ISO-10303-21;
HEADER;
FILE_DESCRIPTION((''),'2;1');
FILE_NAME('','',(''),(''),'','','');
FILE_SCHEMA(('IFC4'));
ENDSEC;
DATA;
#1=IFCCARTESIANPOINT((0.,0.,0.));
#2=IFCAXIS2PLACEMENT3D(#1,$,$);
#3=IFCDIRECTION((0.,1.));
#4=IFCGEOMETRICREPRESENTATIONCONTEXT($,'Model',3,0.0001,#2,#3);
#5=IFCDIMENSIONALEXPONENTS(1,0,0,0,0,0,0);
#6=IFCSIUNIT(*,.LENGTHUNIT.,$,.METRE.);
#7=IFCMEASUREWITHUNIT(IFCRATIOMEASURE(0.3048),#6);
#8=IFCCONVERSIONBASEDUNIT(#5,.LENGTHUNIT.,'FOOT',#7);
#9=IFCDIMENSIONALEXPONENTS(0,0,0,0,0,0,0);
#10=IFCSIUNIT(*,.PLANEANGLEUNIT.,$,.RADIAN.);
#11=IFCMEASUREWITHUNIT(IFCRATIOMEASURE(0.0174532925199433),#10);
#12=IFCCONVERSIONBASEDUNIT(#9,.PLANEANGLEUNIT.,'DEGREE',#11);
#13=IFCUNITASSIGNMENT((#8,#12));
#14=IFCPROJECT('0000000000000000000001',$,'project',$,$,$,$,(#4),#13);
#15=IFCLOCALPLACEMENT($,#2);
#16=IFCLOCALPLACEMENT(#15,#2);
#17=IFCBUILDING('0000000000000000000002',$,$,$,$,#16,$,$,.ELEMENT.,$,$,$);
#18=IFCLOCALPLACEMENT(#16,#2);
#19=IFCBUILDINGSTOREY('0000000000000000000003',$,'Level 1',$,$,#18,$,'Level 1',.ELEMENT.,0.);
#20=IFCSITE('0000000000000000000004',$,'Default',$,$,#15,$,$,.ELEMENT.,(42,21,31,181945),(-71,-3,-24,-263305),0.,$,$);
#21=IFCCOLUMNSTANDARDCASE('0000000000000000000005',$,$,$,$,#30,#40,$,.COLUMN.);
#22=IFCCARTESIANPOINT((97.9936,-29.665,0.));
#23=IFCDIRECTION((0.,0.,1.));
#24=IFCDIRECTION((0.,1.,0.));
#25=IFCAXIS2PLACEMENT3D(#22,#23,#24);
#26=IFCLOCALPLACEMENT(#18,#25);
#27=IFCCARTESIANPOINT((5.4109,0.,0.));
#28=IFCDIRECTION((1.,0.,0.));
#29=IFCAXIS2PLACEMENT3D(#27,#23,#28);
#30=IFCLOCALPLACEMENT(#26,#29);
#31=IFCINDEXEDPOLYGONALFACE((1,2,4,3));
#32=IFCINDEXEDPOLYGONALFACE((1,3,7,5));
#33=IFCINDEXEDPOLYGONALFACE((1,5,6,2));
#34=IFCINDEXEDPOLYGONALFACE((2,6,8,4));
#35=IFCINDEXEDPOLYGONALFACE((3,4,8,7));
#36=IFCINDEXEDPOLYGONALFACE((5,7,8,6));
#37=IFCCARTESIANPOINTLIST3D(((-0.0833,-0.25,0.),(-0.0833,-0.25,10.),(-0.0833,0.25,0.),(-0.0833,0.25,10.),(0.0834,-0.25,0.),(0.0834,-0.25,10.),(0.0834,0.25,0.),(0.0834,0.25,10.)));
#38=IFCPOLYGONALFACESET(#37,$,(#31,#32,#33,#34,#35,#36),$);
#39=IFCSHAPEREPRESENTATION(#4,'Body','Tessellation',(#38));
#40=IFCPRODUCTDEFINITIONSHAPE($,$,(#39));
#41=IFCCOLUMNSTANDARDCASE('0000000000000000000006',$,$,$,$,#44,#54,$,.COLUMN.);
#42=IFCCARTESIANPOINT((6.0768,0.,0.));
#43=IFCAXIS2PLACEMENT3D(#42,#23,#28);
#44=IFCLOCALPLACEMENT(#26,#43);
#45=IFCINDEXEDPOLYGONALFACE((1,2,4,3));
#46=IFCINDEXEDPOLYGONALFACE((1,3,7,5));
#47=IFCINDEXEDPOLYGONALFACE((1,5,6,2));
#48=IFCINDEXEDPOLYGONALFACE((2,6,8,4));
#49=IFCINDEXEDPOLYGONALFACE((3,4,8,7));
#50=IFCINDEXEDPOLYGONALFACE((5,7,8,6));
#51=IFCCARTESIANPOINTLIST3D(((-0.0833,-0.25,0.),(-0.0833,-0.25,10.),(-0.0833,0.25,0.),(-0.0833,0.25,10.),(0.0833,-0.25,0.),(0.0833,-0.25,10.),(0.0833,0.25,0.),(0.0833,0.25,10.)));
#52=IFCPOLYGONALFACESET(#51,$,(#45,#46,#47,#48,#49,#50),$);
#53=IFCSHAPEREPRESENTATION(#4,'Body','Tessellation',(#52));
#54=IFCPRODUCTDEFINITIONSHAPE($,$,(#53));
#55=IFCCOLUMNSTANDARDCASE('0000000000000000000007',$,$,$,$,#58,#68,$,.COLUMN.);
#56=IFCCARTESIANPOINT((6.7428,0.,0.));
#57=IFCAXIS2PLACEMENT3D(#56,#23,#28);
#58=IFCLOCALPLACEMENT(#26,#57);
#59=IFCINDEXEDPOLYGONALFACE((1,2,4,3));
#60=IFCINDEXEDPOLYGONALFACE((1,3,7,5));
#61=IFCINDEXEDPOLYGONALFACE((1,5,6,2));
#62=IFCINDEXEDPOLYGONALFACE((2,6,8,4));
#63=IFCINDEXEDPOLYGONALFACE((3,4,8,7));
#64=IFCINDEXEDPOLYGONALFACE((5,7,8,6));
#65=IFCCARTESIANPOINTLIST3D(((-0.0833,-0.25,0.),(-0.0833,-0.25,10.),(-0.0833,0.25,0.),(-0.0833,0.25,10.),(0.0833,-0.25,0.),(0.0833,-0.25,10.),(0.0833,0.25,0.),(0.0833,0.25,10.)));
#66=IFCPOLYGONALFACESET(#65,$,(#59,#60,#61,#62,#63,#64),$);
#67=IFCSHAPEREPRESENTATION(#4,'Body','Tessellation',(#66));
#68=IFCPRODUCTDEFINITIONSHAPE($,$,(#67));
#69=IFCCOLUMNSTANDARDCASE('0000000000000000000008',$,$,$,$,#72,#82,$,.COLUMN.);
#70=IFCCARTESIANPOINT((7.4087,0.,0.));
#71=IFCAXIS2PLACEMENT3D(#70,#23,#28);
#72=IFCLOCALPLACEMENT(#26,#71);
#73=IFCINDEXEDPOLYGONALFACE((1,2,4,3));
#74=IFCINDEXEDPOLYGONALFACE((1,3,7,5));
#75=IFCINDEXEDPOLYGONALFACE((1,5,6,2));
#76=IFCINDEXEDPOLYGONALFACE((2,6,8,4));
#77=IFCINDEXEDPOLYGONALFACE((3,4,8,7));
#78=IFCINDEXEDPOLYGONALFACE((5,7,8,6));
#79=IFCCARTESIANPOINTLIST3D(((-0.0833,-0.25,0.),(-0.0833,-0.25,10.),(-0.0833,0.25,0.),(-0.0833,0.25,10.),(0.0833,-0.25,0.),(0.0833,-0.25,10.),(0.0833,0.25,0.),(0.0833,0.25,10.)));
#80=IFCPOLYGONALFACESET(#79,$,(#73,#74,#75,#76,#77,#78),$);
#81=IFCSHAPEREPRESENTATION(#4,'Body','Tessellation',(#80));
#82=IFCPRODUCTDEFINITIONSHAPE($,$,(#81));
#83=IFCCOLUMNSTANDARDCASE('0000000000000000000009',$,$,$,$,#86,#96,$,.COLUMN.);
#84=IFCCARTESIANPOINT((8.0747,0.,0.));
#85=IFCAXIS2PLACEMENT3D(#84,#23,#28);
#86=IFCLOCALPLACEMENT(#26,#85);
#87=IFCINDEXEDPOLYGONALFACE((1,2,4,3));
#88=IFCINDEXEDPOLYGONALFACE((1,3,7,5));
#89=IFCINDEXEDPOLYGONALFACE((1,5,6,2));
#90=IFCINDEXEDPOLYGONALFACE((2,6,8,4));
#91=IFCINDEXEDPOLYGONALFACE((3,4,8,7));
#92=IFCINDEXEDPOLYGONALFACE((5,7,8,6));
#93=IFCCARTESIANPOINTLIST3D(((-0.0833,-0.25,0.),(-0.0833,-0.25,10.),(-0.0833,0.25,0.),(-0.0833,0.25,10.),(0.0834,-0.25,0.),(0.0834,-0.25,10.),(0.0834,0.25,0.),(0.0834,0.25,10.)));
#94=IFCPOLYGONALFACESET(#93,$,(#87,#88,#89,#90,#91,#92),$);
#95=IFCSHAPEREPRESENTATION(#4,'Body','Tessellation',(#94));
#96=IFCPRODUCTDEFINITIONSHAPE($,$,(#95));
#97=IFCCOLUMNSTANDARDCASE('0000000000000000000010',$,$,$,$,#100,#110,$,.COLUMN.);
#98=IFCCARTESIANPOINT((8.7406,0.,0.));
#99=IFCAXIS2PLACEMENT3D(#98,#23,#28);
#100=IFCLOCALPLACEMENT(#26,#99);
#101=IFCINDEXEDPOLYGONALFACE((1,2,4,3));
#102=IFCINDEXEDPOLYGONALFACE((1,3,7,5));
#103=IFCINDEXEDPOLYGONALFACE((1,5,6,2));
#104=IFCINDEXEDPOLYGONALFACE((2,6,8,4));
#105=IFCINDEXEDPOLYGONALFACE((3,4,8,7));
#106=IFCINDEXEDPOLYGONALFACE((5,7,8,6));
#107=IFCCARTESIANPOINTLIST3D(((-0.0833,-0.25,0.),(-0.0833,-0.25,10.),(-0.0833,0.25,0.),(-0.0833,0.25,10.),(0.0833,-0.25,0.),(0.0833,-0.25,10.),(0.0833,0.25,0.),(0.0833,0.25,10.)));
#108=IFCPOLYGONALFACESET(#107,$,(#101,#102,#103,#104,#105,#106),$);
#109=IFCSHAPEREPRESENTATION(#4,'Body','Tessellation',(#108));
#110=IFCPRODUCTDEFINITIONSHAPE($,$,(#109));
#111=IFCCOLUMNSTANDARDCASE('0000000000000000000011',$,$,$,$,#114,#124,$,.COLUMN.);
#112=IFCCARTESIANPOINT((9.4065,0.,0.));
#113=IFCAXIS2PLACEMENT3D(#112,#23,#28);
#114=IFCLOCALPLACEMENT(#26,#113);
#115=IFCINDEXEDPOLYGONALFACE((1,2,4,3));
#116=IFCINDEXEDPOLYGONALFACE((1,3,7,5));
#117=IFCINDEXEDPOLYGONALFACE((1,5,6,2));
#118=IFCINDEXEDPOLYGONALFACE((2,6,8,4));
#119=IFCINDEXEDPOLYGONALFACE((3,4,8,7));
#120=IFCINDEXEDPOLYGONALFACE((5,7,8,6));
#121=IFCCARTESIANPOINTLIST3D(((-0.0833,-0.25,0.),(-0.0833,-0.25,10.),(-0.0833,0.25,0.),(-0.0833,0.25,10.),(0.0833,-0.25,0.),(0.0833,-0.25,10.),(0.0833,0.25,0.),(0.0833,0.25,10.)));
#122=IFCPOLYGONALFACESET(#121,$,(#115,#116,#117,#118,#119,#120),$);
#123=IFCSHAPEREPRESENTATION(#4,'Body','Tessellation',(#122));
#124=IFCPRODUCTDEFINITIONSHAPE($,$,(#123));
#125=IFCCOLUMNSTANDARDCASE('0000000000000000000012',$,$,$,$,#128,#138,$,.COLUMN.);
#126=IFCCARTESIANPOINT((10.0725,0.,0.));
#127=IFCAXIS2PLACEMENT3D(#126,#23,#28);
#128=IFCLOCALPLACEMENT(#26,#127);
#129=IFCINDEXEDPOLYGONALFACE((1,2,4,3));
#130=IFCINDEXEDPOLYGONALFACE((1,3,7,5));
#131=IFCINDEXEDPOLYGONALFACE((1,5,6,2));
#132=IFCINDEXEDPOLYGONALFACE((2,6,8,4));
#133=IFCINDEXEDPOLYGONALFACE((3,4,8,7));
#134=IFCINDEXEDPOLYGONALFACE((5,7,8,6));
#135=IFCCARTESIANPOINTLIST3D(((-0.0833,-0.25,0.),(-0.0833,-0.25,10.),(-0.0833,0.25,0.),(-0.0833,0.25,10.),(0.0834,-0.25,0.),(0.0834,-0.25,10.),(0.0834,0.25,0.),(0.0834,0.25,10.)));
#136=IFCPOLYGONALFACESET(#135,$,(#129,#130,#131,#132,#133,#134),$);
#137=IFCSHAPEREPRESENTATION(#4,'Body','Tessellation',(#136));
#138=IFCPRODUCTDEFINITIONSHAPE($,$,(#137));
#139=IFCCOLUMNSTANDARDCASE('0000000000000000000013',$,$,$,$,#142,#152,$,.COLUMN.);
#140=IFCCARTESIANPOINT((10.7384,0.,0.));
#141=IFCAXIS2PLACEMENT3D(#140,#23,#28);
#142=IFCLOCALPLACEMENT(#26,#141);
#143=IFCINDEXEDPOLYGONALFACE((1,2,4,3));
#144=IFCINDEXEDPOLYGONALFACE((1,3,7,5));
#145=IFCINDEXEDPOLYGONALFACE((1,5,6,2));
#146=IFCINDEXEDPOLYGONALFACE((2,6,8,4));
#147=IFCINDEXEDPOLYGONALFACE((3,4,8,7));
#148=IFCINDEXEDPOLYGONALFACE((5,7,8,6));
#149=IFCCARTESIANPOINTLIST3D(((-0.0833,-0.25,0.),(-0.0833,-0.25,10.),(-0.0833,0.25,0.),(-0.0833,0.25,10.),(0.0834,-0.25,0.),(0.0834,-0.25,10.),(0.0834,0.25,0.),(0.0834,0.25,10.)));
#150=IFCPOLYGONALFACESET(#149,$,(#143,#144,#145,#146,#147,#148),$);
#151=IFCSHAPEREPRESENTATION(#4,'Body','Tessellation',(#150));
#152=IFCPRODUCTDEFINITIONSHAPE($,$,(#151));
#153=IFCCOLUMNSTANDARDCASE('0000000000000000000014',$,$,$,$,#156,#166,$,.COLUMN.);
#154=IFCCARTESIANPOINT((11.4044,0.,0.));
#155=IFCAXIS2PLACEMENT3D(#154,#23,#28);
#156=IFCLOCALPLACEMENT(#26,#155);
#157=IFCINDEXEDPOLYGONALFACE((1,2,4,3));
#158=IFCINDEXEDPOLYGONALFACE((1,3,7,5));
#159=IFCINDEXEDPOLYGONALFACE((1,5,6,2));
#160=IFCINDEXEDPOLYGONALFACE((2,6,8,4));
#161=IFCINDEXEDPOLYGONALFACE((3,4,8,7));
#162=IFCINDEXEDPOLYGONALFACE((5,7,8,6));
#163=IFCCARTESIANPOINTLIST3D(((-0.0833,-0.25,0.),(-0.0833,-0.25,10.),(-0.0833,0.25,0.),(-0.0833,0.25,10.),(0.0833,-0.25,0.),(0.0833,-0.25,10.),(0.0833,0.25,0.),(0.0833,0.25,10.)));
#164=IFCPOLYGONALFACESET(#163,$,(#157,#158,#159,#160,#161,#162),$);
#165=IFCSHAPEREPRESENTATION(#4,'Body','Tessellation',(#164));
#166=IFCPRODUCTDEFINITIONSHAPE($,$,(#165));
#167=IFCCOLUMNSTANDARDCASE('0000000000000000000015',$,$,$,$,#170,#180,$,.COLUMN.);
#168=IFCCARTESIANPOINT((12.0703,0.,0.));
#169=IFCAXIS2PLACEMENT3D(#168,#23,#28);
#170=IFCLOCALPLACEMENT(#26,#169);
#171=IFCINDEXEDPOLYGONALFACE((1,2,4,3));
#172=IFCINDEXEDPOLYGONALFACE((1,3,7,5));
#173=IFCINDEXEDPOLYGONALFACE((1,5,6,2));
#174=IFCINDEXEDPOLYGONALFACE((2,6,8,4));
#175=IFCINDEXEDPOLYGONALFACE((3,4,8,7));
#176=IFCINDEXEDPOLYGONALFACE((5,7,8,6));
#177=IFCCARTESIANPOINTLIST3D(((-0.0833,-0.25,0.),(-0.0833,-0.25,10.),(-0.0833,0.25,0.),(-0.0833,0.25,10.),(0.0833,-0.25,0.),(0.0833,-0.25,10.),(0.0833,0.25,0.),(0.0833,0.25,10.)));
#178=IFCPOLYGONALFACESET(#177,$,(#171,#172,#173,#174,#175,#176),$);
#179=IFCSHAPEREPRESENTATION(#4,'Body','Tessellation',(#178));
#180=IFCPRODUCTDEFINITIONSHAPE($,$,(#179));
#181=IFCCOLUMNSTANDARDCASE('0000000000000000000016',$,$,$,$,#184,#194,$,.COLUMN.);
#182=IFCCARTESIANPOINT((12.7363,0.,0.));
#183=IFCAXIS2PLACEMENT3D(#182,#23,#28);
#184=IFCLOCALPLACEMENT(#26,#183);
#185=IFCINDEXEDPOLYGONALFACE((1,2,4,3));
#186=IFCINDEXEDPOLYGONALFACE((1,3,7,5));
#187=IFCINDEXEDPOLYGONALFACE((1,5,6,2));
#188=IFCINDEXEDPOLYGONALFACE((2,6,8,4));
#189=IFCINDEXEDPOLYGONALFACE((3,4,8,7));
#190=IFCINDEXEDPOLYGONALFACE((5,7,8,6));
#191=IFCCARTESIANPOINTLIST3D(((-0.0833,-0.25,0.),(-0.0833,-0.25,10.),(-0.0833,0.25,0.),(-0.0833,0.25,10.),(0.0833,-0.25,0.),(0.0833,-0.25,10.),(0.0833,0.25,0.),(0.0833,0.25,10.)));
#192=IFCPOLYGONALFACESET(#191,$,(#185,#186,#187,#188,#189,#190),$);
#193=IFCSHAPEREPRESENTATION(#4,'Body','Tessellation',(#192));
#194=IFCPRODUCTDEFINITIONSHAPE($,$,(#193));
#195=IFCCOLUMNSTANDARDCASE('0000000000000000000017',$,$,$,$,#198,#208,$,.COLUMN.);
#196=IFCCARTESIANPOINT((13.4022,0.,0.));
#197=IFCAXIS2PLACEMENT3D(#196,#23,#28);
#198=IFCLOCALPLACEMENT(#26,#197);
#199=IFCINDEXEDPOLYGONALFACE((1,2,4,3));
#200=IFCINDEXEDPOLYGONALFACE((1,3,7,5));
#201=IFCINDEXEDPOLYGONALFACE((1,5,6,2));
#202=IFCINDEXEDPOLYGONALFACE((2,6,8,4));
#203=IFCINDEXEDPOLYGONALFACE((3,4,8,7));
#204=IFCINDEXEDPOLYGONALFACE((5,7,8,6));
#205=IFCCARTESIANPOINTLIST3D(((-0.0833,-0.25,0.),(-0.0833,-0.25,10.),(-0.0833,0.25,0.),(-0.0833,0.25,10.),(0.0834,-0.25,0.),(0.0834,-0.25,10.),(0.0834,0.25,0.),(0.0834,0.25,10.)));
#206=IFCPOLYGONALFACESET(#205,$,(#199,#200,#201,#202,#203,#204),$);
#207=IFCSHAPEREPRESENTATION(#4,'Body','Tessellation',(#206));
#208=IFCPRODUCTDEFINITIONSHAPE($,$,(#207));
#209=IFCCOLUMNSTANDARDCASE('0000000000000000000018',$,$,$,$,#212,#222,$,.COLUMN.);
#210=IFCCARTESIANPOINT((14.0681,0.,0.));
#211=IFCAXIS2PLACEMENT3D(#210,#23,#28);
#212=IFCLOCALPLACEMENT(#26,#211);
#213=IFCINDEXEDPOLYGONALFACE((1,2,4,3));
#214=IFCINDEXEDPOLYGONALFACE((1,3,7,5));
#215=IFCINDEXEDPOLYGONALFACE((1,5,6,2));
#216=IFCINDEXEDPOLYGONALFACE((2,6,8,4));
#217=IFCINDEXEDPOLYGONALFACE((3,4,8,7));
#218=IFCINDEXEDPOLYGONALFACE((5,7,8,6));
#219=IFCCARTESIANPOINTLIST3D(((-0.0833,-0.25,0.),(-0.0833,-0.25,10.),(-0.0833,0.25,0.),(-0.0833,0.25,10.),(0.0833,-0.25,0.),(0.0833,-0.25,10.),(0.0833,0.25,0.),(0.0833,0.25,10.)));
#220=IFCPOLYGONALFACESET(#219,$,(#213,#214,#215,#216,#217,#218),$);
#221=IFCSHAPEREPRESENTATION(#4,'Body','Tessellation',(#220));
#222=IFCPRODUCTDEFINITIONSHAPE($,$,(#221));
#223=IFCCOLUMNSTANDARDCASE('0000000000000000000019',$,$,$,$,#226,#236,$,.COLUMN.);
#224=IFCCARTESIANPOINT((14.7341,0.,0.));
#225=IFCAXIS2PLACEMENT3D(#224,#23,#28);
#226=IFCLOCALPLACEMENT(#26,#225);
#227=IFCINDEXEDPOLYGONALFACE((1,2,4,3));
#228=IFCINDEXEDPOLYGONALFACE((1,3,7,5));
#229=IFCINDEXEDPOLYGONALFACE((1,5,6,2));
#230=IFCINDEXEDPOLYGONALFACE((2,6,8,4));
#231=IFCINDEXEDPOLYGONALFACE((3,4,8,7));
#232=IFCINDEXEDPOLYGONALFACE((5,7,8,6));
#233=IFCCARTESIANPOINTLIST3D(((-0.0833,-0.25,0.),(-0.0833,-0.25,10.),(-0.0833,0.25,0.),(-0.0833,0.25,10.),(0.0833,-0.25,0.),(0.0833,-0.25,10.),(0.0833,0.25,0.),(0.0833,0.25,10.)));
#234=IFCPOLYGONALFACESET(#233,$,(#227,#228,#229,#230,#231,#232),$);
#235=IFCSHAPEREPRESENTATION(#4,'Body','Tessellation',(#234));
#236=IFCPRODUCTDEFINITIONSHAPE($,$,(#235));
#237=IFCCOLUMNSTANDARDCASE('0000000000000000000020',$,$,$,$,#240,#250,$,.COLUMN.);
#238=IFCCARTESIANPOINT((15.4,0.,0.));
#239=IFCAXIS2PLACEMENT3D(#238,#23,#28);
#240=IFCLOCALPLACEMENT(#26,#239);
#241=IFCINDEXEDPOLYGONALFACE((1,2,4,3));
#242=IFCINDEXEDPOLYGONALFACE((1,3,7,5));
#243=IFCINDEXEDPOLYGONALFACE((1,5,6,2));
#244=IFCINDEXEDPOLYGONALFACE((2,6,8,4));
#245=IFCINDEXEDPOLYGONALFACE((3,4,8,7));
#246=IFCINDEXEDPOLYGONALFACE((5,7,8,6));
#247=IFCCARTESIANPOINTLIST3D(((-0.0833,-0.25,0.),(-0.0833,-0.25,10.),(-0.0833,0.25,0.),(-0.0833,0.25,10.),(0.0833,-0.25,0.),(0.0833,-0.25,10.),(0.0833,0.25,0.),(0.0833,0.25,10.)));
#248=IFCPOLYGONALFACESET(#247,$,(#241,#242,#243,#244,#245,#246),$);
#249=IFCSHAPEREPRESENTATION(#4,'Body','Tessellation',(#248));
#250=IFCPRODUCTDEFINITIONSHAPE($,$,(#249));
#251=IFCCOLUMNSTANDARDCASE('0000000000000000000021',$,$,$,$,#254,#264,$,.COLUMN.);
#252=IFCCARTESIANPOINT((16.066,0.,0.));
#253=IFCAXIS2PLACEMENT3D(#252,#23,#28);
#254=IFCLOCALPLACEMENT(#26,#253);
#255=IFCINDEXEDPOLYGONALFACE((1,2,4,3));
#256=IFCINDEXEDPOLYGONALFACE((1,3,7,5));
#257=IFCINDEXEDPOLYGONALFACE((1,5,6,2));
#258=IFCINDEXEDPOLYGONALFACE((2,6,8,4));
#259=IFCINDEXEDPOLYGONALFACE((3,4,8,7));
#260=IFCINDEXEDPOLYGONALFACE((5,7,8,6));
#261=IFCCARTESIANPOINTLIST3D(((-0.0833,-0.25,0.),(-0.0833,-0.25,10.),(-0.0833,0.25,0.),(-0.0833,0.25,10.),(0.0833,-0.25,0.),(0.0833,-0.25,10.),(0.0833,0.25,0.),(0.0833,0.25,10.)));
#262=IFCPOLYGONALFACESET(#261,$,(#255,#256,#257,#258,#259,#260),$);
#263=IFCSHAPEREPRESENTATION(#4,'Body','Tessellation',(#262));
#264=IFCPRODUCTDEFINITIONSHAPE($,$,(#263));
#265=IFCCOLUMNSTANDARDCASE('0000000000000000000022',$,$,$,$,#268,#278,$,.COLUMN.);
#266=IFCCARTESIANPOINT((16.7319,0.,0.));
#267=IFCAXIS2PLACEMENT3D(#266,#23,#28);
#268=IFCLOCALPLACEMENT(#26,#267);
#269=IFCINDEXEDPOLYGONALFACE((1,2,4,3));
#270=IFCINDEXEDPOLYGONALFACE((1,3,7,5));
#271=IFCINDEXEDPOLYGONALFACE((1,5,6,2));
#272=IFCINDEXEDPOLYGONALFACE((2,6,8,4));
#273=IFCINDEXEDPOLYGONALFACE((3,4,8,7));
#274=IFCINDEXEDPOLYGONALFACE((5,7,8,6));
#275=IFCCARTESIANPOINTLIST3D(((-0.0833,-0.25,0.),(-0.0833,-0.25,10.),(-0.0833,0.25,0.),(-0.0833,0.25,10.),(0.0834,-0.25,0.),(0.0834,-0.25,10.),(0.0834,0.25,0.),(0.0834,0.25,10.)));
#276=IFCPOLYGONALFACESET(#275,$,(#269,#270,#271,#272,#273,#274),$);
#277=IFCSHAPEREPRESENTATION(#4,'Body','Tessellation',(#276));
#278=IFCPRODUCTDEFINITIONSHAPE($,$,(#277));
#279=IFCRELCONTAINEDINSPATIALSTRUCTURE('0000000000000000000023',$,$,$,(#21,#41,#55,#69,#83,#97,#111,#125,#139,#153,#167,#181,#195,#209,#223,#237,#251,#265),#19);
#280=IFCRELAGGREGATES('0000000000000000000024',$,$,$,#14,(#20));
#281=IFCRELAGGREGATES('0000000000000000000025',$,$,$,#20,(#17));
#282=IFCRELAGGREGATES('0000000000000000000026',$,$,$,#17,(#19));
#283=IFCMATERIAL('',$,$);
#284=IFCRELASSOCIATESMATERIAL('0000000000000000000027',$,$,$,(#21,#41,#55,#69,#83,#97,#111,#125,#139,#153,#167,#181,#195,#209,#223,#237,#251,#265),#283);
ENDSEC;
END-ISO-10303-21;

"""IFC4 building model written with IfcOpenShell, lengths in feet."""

from ifc_helpers import new_model, entity, si_unit, converted_unit, direction, frame, origin, place, context, project, spatial, rectangle, extrude, material, element, save


model = new_model("IFC4")

# Units and contexts
model_context = context("Model", 3, precision=0.0001, world=origin(), true_north=direction((0.0, 1.0)))
ifc_project = project(units=[converted_unit("LENGTHUNIT", "FOOT", entity("IfcRatioMeasure", 0.3048), si_unit("LENGTHUNIT", "METRE"), dimensions=[1, 0, 0, 0, 0, 0, 0]), converted_unit("PLANEANGLEUNIT", "DEGREE", entity("IfcRatioMeasure", 0.0174532925199433), si_unit("PLANEANGLEUNIT", "RADIAN"), dimensions=[0, 0, 0, 0, 0, 0, 0])], contexts=[model_context])

# Site, building, storey
site_placement = place(None, origin())
site = spatial("IfcSite", under=ifc_project, at=site_placement, Name="Default", CompositionType="ELEMENT", RefLatitude=(42, 21, 31, 181945), RefLongitude=(-71, -3, -24, -263305), RefElevation=0.0)
building_placement = place(site_placement, origin())
building = spatial("IfcBuilding", under=site, at=building_placement, CompositionType="ELEMENT")
storey_placement = place(building_placement, origin())
storey = spatial("IfcBuildingStorey", under=building, at=storey_placement, Name="Level 1", LongName="Level 1", CompositionType="ELEMENT", Elevation=0.0)

# Columns
ifc_material = material(Name="")
placement = place(storey_placement, frame((97.9936, -29.665, 0.0), z_axis=(0.0, 0.0, 1.0), x_axis=(0.0, 1.0, 0.0)))
for number, where, z_axis, x_axis in (
    (1, (5.4109, 0.0, 0.0), (0.0, 0.0, 1.0), (1.0, 0.0, 0.0)),
    (2, (6.0768, 0.0, 0.0), (0.0, 0.0, 1.0), (1.0, 0.0, 0.0)),
    (3, (6.7428, 0.0, 0.0), (0.0, 0.0, 1.0), (1.0, 0.0, 0.0)),
    (4, (7.4087, 0.0, 0.0), (0.0, 0.0, 1.0), (1.0, 0.0, 0.0)),
    (5, (8.0747, 0.0, 0.0), (0.0, 0.0, 1.0), (1.0, 0.0, 0.0)),
    (6, (8.7406, 0.0, 0.0), (0.0, 0.0, 1.0), (1.0, 0.0, 0.0)),
    (7, (9.4065, 0.0, 0.0), (0.0, 0.0, 1.0), (1.0, 0.0, 0.0)),
    (8, (10.0725, 0.0, 0.0), (0.0, 0.0, 1.0), (1.0, 0.0, 0.0)),
    (9, (10.7384, 0.0, 0.0), (0.0, 0.0, 1.0), (1.0, 0.0, 0.0)),
    (10, (11.4044, 0.0, 0.0), (0.0, 0.0, 1.0), (1.0, 0.0, 0.0)),
    (11, (12.0703, 0.0, 0.0), (0.0, 0.0, 1.0), (1.0, 0.0, 0.0)),
    (12, (12.7363, 0.0, 0.0), (0.0, 0.0, 1.0), (1.0, 0.0, 0.0)),
    (13, (13.4022, 0.0, 0.0), (0.0, 0.0, 1.0), (1.0, 0.0, 0.0)),
    (14, (14.0681, 0.0, 0.0), (0.0, 0.0, 1.0), (1.0, 0.0, 0.0)),
    (15, (14.7341, 0.0, 0.0), (0.0, 0.0, 1.0), (1.0, 0.0, 0.0)),
    (16, (15.4, 0.0, 0.0), (0.0, 0.0, 1.0), (1.0, 0.0, 0.0)),
    (17, (16.066, 0.0, 0.0), (0.0, 0.0, 1.0), (1.0, 0.0, 0.0)),
    (18, (16.7319, 0.0, 0.0), (0.0, 0.0, 1.0), (1.0, 0.0, 0.0)),
):
    element("IfcColumnStandardCase", number, at=place(placement, frame(where, z_axis=z_axis, x_axis=x_axis)), inside=storey, material=ifc_material, PredefinedType="COLUMN", context=model_context, shape_type="SweptSolid", body=[
        extrude(rectangle(XDim=0.1667, YDim=0.5), origin(), (0.0, 0.0, 1.0), 10.0),
    ])

save(model, "model.ifc")
